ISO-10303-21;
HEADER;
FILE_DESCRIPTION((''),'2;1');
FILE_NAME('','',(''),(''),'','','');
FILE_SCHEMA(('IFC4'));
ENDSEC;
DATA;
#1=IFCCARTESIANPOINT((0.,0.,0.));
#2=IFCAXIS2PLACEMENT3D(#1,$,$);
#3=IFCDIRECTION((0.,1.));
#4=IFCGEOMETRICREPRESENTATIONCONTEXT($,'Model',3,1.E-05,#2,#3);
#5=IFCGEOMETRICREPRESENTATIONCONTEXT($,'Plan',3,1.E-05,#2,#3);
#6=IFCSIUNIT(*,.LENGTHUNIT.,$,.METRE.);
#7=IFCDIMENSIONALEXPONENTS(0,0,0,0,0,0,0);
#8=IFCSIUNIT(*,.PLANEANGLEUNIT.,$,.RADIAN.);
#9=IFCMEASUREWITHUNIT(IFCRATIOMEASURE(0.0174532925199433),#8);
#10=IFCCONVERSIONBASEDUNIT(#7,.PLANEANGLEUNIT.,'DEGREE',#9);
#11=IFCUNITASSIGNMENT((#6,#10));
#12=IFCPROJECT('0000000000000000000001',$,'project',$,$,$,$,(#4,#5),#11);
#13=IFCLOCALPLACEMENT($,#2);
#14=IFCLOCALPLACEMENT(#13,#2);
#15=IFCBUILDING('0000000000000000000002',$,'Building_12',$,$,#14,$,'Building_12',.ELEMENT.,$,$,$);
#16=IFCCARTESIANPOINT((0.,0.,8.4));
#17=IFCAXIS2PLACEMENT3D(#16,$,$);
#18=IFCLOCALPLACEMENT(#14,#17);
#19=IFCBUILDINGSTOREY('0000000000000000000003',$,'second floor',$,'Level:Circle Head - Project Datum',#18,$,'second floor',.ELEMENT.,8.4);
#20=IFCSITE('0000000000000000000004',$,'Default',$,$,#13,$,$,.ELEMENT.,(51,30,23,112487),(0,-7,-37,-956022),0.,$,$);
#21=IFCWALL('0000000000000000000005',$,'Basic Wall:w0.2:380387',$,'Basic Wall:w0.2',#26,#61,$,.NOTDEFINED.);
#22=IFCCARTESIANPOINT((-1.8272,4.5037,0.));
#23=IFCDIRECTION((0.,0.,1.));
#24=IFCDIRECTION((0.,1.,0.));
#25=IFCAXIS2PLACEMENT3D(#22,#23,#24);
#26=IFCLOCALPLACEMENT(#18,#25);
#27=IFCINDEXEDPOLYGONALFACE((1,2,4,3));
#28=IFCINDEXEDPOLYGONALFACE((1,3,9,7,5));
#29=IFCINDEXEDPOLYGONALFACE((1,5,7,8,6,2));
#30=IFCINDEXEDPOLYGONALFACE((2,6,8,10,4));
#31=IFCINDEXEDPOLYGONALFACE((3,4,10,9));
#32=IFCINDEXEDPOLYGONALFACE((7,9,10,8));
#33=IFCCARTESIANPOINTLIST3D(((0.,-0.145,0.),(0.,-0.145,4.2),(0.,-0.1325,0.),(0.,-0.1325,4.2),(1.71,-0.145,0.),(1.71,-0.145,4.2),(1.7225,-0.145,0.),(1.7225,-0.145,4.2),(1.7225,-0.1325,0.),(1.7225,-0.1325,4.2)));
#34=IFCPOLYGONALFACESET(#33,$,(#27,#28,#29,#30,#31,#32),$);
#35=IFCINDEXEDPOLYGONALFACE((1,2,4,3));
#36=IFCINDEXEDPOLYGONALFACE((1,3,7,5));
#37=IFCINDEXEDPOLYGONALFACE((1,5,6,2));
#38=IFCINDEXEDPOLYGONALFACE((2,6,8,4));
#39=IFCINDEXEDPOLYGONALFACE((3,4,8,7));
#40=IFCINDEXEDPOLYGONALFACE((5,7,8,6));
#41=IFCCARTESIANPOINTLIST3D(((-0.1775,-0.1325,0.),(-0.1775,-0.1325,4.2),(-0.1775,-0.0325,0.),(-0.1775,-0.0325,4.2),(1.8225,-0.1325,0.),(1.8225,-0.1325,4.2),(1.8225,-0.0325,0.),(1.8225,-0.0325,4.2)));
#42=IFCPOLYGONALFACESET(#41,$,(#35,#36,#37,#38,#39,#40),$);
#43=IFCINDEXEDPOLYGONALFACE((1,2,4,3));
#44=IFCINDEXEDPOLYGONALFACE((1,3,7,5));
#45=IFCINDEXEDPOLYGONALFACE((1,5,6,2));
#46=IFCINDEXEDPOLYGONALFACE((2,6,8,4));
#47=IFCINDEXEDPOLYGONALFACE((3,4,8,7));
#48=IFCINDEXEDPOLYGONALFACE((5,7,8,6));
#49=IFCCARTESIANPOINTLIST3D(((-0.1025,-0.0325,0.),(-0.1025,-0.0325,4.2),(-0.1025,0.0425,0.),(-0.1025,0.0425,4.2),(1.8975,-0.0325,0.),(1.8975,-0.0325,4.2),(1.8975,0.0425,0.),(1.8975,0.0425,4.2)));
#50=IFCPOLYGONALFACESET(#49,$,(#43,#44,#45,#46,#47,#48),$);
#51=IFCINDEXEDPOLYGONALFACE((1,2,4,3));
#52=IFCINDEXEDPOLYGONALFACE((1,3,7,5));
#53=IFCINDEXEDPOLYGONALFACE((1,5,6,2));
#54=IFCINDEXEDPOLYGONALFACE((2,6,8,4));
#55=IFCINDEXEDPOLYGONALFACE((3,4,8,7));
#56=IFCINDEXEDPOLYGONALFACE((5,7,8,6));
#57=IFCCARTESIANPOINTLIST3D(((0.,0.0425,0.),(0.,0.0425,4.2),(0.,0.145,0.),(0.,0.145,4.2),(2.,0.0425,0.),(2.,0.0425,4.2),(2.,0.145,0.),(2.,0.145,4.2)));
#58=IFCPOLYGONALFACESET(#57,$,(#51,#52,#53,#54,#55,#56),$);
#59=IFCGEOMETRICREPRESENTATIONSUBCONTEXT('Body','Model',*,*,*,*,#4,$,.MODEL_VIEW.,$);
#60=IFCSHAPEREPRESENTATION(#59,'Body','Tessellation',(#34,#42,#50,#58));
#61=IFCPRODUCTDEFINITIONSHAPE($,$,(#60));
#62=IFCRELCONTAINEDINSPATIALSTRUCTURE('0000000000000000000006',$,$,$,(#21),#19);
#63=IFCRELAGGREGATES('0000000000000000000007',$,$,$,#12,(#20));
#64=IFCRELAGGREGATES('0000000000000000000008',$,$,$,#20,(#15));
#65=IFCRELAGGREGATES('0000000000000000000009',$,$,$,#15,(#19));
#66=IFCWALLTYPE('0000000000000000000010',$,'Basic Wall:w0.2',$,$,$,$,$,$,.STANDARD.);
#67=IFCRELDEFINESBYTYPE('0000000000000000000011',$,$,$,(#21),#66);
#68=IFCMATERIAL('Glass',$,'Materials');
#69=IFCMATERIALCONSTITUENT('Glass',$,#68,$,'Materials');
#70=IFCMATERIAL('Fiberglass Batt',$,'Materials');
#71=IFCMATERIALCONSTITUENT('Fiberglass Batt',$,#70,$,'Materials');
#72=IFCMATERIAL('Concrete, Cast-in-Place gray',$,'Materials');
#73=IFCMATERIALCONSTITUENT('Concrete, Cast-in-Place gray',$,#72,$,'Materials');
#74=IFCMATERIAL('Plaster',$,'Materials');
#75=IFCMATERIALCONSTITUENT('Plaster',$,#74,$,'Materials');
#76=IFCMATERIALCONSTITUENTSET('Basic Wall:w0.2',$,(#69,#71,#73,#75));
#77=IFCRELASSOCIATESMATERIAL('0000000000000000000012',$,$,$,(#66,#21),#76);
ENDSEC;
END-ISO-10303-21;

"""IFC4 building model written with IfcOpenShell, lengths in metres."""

from ifc_helpers import new_model, entity, si_unit, converted_unit, direction, frame, origin, place, context, subcontext, project, spatial, indexed_curve, outline, extrude, material, constituent, constituent_set, type_object, element, save


model = new_model("IFC4")

# Units and contexts
model_context = context("Model", 3, precision=1e-05, world=origin(), true_north=direction((0.0, 1.0)))
plan_context = context("Plan", 3, precision=1e-05, world=origin(), true_north=direction((0.0, 1.0)))
body_context = subcontext(model_context, "Body", "Model", "MODEL_VIEW")
ifc_project = project(units=[si_unit("LENGTHUNIT", "METRE"), converted_unit("PLANEANGLEUNIT", "DEGREE", entity("IfcRatioMeasure", 0.0174532925199433), si_unit("PLANEANGLEUNIT", "RADIAN"), dimensions=[0, 0, 0, 0, 0, 0, 0])], contexts=[model_context, plan_context])

# Site, building, storey
site_placement = place(None, origin())
site = spatial("IfcSite", under=ifc_project, at=site_placement, Name="Default", CompositionType="ELEMENT", RefLatitude=(51, 30, 23, 112487), RefLongitude=(0, -7, -37, -956022), RefElevation=0.0)
building_placement = place(site_placement, origin())
building = spatial("IfcBuilding", under=site, at=building_placement, Name="Building_12", LongName="Building_12", CompositionType="ELEMENT")
storey_placement = place(building_placement, frame((0.0, 0.0, 8.4)))
storey = spatial("IfcBuildingStorey", under=building, at=storey_placement, Name="second floor", ObjectType="Level:Circle Head - Project Datum", LongName="second floor", CompositionType="ELEMENT", Elevation=8.4)

# Shared definitions
ifc_material_1 = material(Name="Plaster", Category="Materials")

# Shared definitions
ifc_material_2 = material(Name="Concrete, Cast-in-Place gray", Category="Materials")

# Shared definitions
ifc_material_3 = material(Name="Glass", Category="Materials")
ifc_constituent_1 = constituent(ifc_material_3, Name="Glass", Category="Materials")
ifc_material_4 = material(Name="Fiberglass Batt", Category="Materials")
ifc_constituent_2 = constituent(ifc_material_4, Name="Fiberglass Batt", Category="Materials")
ifc_constituent_3 = constituent(ifc_material_2, Name="Concrete, Cast-in-Place gray", Category="Materials")
ifc_constituent_4 = constituent(ifc_material_1, Name="Plaster", Category="Materials")
ifc_constituent_set_1 = constituent_set(constituents=[ifc_constituent_1, ifc_constituent_2, ifc_constituent_3, ifc_constituent_4], Name="Basic Wall:w0.2")
wall_type = type_object("IfcWallType", Name="Basic Wall:w0.2", PredefinedType="STANDARD", material=ifc_constituent_set_1)

# Wall
wall_1_placement = place(storey_placement, frame((-1.8272, 4.5037, 0.0), z_axis=(0.0, 0.0, 1.0), x_axis=(0.0, 1.0, 0.0)))
element("IfcWall", 1, at=wall_1_placement, inside=storey, type_object=wall_type, material=ifc_constituent_set_1, Name="Basic Wall:w0.2:380387", ObjectType="Basic Wall:w0.2", PredefinedType="NOTDEFINED", context=body_context, shape_type="SweptSolid", body=[
    extrude(outline(indexed_curve([(0.679, -0.005), (0.6915, -0.005), (0.6915, 0.0075), (-1.031, 0.0075), (-1.031, -0.005), (0.679, -0.005)], self_intersect=False)), frame((1.031, -0.14, 0.0)), (0.0, 0.0, 1.0), 4.2),
    extrude(outline(indexed_curve([(-1.0, -0.05), (1.0, -0.05), (1.0, 0.05), (-1.0, 0.05), (-1.0, -0.05)], self_intersect=False)), frame((0.8225, -0.0825, 0.0)), (0.0, 0.0, 1.0), 4.2),
    extrude(outline(indexed_curve([(-1.0, -0.0375), (1.0, -0.0375), (1.0, 0.0375), (-1.0, 0.0375), (-1.0, -0.0375)], self_intersect=False)), frame((0.8975, 0.005, 0.0)), (0.0, 0.0, 1.0), 4.2),
    extrude(outline(indexed_curve([(-0.0512, -1.0), (0.0513, -1.0), (0.0512, 1.0), (-0.0513, 1.0), (-0.0512, -1.0)], self_intersect=False)), frame((1.0, 0.0937, 0.0), z_axis=(0.0, 0.0, 1.0), x_axis=(0.0, -1.0, 0.0)), (0.0, 0.0, 1.0), 4.2),
])

save(model, "model.ifc")
